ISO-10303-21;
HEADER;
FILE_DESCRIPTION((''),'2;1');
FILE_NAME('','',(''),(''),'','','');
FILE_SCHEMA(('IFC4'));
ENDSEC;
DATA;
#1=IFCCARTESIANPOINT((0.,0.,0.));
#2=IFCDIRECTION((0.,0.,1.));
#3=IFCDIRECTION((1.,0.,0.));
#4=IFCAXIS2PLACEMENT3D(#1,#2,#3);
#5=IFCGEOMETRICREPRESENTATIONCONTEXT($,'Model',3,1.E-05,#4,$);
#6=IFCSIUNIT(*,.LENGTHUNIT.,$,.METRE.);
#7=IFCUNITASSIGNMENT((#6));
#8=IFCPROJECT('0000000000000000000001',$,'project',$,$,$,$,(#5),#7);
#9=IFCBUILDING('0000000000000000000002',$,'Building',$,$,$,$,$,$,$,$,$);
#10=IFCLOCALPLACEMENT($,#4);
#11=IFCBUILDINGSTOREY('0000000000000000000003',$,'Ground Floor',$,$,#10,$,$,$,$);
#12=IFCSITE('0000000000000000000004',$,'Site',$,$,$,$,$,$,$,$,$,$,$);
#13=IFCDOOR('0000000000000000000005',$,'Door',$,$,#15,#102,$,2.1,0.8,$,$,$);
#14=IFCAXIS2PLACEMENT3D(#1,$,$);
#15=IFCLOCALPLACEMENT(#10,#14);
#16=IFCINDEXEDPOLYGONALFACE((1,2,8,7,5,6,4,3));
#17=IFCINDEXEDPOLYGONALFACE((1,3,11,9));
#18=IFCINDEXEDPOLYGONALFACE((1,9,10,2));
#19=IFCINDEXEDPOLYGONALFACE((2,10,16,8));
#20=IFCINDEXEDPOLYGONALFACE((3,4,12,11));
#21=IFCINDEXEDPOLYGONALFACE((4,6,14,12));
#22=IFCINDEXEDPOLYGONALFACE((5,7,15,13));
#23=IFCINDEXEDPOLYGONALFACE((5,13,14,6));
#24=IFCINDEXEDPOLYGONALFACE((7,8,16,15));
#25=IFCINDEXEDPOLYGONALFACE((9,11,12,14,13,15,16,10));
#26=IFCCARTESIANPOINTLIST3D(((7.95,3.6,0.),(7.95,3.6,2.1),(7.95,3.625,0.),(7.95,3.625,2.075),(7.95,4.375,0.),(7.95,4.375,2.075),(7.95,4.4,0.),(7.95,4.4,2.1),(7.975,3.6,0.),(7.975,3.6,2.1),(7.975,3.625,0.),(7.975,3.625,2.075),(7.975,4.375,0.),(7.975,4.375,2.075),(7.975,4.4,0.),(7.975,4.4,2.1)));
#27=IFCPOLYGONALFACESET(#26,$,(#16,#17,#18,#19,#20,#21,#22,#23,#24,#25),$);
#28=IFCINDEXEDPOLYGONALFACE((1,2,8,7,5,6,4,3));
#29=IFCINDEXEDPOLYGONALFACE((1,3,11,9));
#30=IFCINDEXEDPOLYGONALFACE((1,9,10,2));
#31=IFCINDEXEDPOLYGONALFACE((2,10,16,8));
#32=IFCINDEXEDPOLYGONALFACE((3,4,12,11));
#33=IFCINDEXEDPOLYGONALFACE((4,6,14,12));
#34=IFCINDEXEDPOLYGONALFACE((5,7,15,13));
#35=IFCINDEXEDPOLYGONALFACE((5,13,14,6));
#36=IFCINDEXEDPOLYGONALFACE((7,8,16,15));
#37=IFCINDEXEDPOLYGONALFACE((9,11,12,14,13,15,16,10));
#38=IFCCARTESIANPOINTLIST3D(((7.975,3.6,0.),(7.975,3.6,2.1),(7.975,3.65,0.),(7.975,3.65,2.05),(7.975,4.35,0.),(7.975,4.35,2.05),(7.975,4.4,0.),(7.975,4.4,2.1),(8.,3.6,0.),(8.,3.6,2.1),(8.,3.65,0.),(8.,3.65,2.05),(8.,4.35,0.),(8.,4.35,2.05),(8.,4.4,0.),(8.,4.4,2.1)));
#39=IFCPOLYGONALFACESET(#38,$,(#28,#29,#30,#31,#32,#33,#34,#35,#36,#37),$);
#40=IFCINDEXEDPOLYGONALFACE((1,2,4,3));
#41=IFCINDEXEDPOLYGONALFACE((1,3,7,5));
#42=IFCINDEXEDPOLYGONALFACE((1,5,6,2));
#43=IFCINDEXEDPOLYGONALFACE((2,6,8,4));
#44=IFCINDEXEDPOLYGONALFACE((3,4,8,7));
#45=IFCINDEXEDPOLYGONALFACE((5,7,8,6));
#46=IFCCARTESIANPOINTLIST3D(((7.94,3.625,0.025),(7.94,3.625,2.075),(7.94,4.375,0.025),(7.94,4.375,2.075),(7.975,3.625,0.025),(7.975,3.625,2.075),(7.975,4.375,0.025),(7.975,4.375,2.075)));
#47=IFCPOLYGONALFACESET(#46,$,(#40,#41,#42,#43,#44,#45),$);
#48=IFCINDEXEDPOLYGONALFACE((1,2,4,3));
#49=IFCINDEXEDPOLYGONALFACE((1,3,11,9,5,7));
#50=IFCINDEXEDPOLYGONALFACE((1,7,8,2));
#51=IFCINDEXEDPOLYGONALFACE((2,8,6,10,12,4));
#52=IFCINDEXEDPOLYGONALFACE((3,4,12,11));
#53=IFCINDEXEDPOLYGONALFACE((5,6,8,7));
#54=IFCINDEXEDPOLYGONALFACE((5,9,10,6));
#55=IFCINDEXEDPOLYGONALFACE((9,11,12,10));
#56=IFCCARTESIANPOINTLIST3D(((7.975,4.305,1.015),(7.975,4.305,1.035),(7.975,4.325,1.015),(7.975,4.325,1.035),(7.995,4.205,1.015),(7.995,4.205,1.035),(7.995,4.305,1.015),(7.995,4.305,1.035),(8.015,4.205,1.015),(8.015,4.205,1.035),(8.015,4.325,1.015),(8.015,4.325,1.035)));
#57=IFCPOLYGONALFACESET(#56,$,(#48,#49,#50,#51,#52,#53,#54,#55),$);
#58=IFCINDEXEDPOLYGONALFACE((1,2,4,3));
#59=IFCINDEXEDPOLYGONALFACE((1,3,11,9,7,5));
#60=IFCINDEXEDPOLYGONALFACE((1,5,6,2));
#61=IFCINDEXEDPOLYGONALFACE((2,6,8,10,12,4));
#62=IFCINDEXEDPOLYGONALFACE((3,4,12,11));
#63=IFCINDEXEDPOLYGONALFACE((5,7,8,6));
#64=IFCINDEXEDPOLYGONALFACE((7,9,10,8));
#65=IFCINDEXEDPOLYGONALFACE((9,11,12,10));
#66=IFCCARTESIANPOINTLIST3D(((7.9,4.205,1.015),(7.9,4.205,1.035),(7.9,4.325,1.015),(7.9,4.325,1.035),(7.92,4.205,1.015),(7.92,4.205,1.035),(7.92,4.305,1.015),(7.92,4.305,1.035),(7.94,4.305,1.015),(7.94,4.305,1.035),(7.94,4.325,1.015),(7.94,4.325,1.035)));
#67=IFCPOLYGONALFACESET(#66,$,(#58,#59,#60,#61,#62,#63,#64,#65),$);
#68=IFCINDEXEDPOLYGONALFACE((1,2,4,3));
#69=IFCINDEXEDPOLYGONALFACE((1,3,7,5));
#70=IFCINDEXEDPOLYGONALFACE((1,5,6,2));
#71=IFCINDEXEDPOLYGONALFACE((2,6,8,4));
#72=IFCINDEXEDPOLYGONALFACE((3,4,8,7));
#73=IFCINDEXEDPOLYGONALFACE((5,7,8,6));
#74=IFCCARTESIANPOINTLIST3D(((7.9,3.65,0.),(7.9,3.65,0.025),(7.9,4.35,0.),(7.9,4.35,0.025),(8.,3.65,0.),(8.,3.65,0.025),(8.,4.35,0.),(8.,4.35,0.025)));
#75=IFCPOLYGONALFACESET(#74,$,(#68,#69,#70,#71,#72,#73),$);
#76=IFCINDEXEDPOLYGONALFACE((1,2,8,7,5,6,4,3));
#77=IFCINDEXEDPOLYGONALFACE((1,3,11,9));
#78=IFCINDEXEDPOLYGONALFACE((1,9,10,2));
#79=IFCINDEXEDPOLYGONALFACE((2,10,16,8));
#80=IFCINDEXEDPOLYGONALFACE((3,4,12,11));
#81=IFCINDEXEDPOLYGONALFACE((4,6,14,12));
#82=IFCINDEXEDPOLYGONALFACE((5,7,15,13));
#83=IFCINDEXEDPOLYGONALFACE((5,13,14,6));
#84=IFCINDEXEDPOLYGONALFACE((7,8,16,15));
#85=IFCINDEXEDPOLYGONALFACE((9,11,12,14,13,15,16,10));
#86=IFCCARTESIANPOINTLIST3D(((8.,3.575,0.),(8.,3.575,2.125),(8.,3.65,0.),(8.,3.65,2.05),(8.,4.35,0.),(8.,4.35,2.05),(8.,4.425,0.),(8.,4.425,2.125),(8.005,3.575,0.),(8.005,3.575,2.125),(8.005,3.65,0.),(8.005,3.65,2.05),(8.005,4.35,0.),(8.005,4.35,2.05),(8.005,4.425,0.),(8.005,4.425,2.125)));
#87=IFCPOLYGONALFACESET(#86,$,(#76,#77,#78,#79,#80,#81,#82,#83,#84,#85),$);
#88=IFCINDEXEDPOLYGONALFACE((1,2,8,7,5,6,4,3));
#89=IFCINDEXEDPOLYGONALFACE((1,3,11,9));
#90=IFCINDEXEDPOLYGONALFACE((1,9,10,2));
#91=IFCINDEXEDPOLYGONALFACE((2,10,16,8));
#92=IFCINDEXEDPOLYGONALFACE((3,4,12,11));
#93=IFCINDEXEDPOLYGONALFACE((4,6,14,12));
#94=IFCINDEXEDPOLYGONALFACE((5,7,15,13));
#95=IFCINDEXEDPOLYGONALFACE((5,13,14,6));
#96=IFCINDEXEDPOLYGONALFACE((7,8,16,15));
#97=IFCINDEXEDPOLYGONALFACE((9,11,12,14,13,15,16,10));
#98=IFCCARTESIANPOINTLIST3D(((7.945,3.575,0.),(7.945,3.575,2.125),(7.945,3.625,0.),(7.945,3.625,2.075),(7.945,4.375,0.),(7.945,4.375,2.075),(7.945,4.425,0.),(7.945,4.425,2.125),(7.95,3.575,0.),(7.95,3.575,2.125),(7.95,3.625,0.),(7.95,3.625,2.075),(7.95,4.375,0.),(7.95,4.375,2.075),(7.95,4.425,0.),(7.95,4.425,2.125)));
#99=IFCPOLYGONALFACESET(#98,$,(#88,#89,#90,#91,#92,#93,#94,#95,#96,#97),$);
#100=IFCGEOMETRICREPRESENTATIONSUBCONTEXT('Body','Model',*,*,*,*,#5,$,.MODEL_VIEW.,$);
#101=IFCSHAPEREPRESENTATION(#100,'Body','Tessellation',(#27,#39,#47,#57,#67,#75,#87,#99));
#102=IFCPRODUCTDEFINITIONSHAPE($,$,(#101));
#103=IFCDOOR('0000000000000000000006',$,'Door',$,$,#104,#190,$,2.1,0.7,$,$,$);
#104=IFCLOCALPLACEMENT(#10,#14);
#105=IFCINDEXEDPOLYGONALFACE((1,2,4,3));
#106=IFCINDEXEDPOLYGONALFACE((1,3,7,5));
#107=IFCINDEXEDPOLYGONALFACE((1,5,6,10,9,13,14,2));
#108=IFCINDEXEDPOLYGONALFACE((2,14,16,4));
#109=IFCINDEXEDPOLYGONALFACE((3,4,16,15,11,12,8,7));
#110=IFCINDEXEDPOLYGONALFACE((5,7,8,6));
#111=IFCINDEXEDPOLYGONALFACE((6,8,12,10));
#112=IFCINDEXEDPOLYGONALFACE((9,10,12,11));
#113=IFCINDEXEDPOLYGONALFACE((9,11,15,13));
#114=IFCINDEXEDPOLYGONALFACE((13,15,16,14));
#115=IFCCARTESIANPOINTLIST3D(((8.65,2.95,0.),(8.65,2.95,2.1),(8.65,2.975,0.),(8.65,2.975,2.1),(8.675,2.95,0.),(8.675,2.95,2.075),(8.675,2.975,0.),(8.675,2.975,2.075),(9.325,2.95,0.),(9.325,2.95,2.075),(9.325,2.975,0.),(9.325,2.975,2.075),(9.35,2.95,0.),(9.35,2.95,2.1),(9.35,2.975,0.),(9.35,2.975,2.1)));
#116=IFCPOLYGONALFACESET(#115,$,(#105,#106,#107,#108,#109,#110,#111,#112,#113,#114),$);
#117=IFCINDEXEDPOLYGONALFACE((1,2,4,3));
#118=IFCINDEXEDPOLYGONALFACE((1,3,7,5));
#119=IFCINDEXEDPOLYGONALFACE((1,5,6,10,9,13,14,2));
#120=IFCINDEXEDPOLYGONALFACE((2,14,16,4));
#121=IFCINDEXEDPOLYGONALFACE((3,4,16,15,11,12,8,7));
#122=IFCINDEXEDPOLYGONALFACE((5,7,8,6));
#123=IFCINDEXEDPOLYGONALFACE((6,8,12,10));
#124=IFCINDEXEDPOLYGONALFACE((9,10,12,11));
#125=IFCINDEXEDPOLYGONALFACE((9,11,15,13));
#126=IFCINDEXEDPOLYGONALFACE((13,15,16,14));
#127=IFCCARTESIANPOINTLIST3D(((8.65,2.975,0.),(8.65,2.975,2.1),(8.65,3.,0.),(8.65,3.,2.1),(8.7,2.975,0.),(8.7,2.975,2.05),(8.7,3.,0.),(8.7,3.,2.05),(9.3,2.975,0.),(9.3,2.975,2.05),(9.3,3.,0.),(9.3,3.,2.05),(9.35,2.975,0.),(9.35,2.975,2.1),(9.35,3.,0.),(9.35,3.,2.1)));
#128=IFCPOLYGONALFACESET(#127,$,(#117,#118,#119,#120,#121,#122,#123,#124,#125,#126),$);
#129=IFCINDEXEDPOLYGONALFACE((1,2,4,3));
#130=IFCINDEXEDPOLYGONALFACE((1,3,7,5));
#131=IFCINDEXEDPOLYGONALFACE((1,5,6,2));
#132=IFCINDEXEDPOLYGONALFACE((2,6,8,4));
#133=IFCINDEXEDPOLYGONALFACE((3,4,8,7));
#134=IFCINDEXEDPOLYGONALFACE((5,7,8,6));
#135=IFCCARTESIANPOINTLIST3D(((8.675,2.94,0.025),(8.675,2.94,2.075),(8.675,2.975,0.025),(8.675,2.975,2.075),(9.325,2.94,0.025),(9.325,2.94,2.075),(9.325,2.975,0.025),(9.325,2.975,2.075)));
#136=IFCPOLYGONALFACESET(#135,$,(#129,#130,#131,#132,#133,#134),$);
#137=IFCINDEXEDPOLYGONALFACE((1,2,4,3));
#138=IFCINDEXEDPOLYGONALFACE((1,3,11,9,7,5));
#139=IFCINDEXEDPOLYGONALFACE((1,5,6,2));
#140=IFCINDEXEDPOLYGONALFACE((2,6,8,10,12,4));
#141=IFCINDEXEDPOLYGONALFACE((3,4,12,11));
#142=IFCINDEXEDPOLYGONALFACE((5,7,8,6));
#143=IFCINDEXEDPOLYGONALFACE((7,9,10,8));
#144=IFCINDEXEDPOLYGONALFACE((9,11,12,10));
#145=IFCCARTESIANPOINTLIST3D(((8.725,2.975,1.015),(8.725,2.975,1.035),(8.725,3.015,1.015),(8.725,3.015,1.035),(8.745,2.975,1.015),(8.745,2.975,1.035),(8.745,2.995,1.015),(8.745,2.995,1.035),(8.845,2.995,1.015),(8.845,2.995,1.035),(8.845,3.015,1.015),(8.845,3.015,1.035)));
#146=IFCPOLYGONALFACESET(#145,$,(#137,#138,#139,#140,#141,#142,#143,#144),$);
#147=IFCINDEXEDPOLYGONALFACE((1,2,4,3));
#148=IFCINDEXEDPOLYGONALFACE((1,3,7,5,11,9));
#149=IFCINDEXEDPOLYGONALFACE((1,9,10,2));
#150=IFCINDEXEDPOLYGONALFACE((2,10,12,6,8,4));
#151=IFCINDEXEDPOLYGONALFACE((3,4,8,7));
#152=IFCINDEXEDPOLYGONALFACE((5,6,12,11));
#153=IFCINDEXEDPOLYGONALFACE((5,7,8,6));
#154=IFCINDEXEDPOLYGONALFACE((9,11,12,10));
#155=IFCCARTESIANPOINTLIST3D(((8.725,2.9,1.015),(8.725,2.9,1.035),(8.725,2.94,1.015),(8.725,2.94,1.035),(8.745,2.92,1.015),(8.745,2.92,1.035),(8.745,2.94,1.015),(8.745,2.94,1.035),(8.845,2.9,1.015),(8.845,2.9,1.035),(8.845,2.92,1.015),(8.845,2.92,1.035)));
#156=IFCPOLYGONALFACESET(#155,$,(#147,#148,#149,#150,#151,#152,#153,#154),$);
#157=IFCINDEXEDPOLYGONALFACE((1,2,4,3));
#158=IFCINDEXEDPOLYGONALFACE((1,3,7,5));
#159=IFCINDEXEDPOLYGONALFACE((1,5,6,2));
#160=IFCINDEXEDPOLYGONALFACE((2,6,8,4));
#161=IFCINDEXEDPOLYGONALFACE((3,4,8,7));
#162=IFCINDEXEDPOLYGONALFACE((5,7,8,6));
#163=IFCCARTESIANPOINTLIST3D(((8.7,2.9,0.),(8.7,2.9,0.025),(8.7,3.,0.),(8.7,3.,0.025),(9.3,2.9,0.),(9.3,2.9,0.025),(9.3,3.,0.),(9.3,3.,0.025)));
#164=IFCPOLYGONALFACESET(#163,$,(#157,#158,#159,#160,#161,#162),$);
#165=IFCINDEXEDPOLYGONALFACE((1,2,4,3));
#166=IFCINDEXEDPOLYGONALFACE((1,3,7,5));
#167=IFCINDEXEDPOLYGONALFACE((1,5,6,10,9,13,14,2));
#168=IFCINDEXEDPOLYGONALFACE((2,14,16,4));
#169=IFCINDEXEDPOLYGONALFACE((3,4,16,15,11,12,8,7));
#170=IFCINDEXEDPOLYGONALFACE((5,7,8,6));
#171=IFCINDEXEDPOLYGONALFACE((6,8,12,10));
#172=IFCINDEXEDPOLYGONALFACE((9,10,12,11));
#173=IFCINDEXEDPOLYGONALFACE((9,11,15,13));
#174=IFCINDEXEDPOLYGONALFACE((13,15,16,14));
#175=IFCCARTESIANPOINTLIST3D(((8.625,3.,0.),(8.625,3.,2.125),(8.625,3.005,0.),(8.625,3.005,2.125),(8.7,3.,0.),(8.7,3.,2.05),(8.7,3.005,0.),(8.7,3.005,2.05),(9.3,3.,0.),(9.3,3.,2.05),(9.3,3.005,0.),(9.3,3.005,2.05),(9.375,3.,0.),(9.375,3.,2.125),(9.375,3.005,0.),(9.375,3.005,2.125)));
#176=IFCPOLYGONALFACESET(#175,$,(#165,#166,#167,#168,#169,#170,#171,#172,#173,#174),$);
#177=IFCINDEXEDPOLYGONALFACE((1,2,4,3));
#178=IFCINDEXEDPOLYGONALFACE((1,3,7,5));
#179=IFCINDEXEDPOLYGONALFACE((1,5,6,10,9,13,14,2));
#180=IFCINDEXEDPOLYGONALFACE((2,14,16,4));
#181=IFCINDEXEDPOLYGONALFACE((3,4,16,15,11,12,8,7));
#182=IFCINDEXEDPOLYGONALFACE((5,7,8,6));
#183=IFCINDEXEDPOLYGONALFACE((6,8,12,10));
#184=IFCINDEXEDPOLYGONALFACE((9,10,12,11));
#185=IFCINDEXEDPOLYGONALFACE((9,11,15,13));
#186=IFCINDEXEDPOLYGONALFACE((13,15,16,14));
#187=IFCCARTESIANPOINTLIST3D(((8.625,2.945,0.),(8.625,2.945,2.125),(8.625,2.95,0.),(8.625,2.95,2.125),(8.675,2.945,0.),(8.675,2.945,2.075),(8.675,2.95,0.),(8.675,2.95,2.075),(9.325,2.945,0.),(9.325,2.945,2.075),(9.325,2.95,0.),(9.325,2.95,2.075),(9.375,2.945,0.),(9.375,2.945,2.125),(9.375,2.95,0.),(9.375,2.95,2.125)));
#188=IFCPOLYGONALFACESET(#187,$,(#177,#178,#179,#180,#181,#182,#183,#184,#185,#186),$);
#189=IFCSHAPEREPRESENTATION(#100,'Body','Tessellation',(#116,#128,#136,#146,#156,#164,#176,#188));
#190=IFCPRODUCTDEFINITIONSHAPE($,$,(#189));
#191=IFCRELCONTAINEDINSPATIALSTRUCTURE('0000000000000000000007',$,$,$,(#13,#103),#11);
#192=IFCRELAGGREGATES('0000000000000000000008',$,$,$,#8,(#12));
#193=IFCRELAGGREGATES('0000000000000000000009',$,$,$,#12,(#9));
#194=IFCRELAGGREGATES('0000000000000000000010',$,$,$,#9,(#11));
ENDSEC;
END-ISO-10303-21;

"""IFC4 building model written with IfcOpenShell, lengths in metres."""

from ifc_helpers import new_model, si_unit, frame, origin_with_axes, place, context, subcontext, project, spatial, line, indexed_curve, outline, extrude, element, save


model = new_model("IFC4")

# Units and contexts
model_context = context("Model", 3, precision=1e-05, world=origin_with_axes())
body_context = subcontext(model_context, "Body", "Model", "MODEL_VIEW")
ifc_project = project(units=[si_unit("LENGTHUNIT", "METRE")], contexts=[model_context])

# Site, building, storey
site = spatial("IfcSite", under=ifc_project, Name="Site")
building = spatial("IfcBuilding", under=site, Name="Building")
storey_placement = place(None, origin_with_axes())
storey = spatial("IfcBuildingStorey", under=building, at=storey_placement, Name="Ground Floor")

# Doors
door_1_placement = place(storey_placement, frame((8.0, 3.6, 0.0), z_axis=(0.0, 0.0, 1.0), x_axis=(0.0, 1.0, 0.0)))
element("IfcDoor", 1, at=door_1_placement, inside=storey, Name="Door", OverallHeight=2.1, OverallWidth=0.8, context=body_context, shape_type="SweptSolid", body=[
    extrude(outline(indexed_curve([(0.0, 0.0), (0.0, 2.1), (0.8, 2.1), (0.8, 0.0), (0.775, 0.0), (0.775, 2.075), (0.025, 2.075), (0.025, 0.0)], segments=[line(1, 2, 3, 4, 5, 6, 7, 8, 1)])), frame((0.0, 0.025, 0.0), z_axis=(0.0, -1.0, 0.0), x_axis=(1.0, 0.0, 0.0)), (0.0, 0.0, -1.0), 0.025),
    extrude(outline(indexed_curve([(0.0, 0.0), (0.0, 2.1), (0.8, 2.1), (0.8, 0.0), (0.75, 0.0), (0.75, 2.05), (0.05, 2.05), (0.05, 0.0)], segments=[line(1, 2, 3, 4, 5, 6, 7, 8, 1)])), frame((0.0, 0.0, 0.0), z_axis=(0.0, -1.0, 0.0), x_axis=(1.0, 0.0, 0.0)), (0.0, 0.0, -1.0), 0.025),
    extrude(outline(indexed_curve([(0.0, 0.0), (0.75, 0.0), (0.75, 0.035), (0.0, 0.035)], segments=[line(1, 2, 3, 4, 1)])), frame((0.025, 0.025, 0.025), z_axis=(0.0, 0.0, 1.0), x_axis=(1.0, 0.0, 0.0)), (0.0, 0.0, 1.0), 2.05),
    extrude(outline(indexed_curve([(0.0, 0.0), (0.0, -0.04), (-0.12, -0.04), (-0.12, -0.02), (-0.02, -0.02), (-0.02, 0.0)], segments=[line(1, 2, 3, 4, 5, 6, 1)])), frame((0.725, 0.025, 1.015), z_axis=(0.0, 0.0, 1.0), x_axis=(1.0, 0.0, 0.0)), (0.0, 0.0, 1.0), 0.02),
    extrude(outline(indexed_curve([(0.0, 0.0), (0.0, 0.04), (-0.12, 0.04), (-0.12, 0.02), (-0.02, 0.02), (-0.02, 0.0)], segments=[line(1, 2, 3, 4, 5, 6, 1)])), frame((0.725, 0.06, 1.015), z_axis=(0.0, 0.0, 1.0), x_axis=(1.0, 0.0, 0.0)), (0.0, 0.0, 1.0), 0.02),
    extrude(outline(indexed_curve([(0.0, 0.0), (0.7, 0.0), (0.7, 0.1), (0.0, 0.1)], segments=[line(1, 2, 3, 4, 1)])), frame((0.05, 0.0, 0.0), z_axis=(0.0, 0.0, 1.0), x_axis=(1.0, 0.0, 0.0)), (0.0, 0.0, 1.0), 0.025),
    extrude(outline(indexed_curve([(0.0, 0.0), (0.0, 2.125), (0.85, 2.125), (0.85, 0.0), (0.775, 0.0), (0.775, 2.05), (0.075, 2.05), (0.075, 0.0)], segments=[line(1, 2, 3, 4, 5, 6, 7, 8, 1)])), frame((-0.025, -0.005, 0.0), z_axis=(0.0, -1.0, 0.0), x_axis=(1.0, 0.0, 0.0)), (0.0, 0.0, -1.0), 0.005),
    extrude(outline(indexed_curve([(0.0, 0.0), (0.0, 2.125), (0.85, 2.125), (0.85, 0.0), (0.8, 0.0), (0.8, 2.075), (0.05, 2.075), (0.05, 0.0)], segments=[line(1, 2, 3, 4, 5, 6, 7, 8, 1)])), frame((-0.025, 0.05, 0.0), z_axis=(0.0, -1.0, 0.0), x_axis=(1.0, 0.0, 0.0)), (0.0, 0.0, -1.0), 0.005),
])
door_2_placement = place(storey_placement, frame((9.35, 3.0, 0.0), z_axis=(0.0, 0.0, 1.0), x_axis=(-1.0, 0.0, 0.0)))
element("IfcDoor", 2, at=door_2_placement, inside=storey, Name="Door", OverallHeight=2.1, OverallWidth=0.7, context=body_context, shape_type="SweptSolid", body=[
    extrude(outline(indexed_curve([(0.0, 0.0), (0.0, 2.1), (0.7, 2.1), (0.7, 0.0), (0.675, 0.0), (0.675, 2.075), (0.025, 2.075), (0.025, 0.0)], segments=[line(1, 2, 3, 4, 5, 6, 7, 8, 1)])), frame((0.0, 0.025, 0.0), z_axis=(0.0, -1.0, 0.0), x_axis=(1.0, 0.0, 0.0)), (0.0, 0.0, -1.0), 0.025),
    extrude(outline(indexed_curve([(0.0, 0.0), (0.0, 2.1), (0.7, 2.1), (0.7, 0.0), (0.65, 0.0), (0.65, 2.05), (0.05, 2.05), (0.05, 0.0)], segments=[line(1, 2, 3, 4, 5, 6, 7, 8, 1)])), frame((0.0, 0.0, 0.0), z_axis=(0.0, -1.0, 0.0), x_axis=(1.0, 0.0, 0.0)), (0.0, 0.0, -1.0), 0.025),
    extrude(outline(indexed_curve([(0.0, 0.0), (0.65, 0.0), (0.65, 0.035), (0.0, 0.035)], segments=[line(1, 2, 3, 4, 1)])), frame((0.025, 0.025, 0.025), z_axis=(0.0, 0.0, 1.0), x_axis=(1.0, 0.0, 0.0)), (0.0, 0.0, 1.0), 2.05),
    extrude(outline(indexed_curve([(0.0, 0.0), (0.0, -0.04), (-0.12, -0.04), (-0.12, -0.02), (-0.02, -0.02), (-0.02, 0.0)], segments=[line(1, 2, 3, 4, 5, 6, 1)])), frame((0.625, 0.025, 1.015), z_axis=(0.0, 0.0, 1.0), x_axis=(1.0, 0.0, 0.0)), (0.0, 0.0, 1.0), 0.02),
    extrude(outline(indexed_curve([(0.0, 0.0), (0.0, 0.04), (-0.12, 0.04), (-0.12, 0.02), (-0.02, 0.02), (-0.02, 0.0)], segments=[line(1, 2, 3, 4, 5, 6, 1)])), frame((0.625, 0.06, 1.015), z_axis=(0.0, 0.0, 1.0), x_axis=(1.0, 0.0, 0.0)), (0.0, 0.0, 1.0), 0.02),
    extrude(outline(indexed_curve([(0.0, 0.0), (0.6, 0.0), (0.6, 0.1), (0.0, 0.1)], segments=[line(1, 2, 3, 4, 1)])), frame((0.05, 0.0, 0.0), z_axis=(0.0, 0.0, 1.0), x_axis=(1.0, 0.0, 0.0)), (0.0, 0.0, 1.0), 0.025),
    extrude(outline(indexed_curve([(0.0, 0.0), (0.0, 2.125), (0.75, 2.125), (0.75, 0.0), (0.675, 0.0), (0.675, 2.05), (0.075, 2.05), (0.075, 0.0)], segments=[line(1, 2, 3, 4, 5, 6, 7, 8, 1)])), frame((-0.025, -0.005, 0.0), z_axis=(0.0, -1.0, 0.0), x_axis=(1.0, 0.0, 0.0)), (0.0, 0.0, -1.0), 0.005),
    extrude(outline(indexed_curve([(0.0, 0.0), (0.0, 2.125), (0.75, 2.125), (0.75, 0.0), (0.7, 0.0), (0.7, 2.075), (0.05, 2.075), (0.05, 0.0)], segments=[line(1, 2, 3, 4, 5, 6, 7, 8, 1)])), frame((-0.025, 0.05, 0.0), z_axis=(0.0, -1.0, 0.0), x_axis=(1.0, 0.0, 0.0)), (0.0, 0.0, -1.0), 0.005),
])

save(model, "model.ifc")
